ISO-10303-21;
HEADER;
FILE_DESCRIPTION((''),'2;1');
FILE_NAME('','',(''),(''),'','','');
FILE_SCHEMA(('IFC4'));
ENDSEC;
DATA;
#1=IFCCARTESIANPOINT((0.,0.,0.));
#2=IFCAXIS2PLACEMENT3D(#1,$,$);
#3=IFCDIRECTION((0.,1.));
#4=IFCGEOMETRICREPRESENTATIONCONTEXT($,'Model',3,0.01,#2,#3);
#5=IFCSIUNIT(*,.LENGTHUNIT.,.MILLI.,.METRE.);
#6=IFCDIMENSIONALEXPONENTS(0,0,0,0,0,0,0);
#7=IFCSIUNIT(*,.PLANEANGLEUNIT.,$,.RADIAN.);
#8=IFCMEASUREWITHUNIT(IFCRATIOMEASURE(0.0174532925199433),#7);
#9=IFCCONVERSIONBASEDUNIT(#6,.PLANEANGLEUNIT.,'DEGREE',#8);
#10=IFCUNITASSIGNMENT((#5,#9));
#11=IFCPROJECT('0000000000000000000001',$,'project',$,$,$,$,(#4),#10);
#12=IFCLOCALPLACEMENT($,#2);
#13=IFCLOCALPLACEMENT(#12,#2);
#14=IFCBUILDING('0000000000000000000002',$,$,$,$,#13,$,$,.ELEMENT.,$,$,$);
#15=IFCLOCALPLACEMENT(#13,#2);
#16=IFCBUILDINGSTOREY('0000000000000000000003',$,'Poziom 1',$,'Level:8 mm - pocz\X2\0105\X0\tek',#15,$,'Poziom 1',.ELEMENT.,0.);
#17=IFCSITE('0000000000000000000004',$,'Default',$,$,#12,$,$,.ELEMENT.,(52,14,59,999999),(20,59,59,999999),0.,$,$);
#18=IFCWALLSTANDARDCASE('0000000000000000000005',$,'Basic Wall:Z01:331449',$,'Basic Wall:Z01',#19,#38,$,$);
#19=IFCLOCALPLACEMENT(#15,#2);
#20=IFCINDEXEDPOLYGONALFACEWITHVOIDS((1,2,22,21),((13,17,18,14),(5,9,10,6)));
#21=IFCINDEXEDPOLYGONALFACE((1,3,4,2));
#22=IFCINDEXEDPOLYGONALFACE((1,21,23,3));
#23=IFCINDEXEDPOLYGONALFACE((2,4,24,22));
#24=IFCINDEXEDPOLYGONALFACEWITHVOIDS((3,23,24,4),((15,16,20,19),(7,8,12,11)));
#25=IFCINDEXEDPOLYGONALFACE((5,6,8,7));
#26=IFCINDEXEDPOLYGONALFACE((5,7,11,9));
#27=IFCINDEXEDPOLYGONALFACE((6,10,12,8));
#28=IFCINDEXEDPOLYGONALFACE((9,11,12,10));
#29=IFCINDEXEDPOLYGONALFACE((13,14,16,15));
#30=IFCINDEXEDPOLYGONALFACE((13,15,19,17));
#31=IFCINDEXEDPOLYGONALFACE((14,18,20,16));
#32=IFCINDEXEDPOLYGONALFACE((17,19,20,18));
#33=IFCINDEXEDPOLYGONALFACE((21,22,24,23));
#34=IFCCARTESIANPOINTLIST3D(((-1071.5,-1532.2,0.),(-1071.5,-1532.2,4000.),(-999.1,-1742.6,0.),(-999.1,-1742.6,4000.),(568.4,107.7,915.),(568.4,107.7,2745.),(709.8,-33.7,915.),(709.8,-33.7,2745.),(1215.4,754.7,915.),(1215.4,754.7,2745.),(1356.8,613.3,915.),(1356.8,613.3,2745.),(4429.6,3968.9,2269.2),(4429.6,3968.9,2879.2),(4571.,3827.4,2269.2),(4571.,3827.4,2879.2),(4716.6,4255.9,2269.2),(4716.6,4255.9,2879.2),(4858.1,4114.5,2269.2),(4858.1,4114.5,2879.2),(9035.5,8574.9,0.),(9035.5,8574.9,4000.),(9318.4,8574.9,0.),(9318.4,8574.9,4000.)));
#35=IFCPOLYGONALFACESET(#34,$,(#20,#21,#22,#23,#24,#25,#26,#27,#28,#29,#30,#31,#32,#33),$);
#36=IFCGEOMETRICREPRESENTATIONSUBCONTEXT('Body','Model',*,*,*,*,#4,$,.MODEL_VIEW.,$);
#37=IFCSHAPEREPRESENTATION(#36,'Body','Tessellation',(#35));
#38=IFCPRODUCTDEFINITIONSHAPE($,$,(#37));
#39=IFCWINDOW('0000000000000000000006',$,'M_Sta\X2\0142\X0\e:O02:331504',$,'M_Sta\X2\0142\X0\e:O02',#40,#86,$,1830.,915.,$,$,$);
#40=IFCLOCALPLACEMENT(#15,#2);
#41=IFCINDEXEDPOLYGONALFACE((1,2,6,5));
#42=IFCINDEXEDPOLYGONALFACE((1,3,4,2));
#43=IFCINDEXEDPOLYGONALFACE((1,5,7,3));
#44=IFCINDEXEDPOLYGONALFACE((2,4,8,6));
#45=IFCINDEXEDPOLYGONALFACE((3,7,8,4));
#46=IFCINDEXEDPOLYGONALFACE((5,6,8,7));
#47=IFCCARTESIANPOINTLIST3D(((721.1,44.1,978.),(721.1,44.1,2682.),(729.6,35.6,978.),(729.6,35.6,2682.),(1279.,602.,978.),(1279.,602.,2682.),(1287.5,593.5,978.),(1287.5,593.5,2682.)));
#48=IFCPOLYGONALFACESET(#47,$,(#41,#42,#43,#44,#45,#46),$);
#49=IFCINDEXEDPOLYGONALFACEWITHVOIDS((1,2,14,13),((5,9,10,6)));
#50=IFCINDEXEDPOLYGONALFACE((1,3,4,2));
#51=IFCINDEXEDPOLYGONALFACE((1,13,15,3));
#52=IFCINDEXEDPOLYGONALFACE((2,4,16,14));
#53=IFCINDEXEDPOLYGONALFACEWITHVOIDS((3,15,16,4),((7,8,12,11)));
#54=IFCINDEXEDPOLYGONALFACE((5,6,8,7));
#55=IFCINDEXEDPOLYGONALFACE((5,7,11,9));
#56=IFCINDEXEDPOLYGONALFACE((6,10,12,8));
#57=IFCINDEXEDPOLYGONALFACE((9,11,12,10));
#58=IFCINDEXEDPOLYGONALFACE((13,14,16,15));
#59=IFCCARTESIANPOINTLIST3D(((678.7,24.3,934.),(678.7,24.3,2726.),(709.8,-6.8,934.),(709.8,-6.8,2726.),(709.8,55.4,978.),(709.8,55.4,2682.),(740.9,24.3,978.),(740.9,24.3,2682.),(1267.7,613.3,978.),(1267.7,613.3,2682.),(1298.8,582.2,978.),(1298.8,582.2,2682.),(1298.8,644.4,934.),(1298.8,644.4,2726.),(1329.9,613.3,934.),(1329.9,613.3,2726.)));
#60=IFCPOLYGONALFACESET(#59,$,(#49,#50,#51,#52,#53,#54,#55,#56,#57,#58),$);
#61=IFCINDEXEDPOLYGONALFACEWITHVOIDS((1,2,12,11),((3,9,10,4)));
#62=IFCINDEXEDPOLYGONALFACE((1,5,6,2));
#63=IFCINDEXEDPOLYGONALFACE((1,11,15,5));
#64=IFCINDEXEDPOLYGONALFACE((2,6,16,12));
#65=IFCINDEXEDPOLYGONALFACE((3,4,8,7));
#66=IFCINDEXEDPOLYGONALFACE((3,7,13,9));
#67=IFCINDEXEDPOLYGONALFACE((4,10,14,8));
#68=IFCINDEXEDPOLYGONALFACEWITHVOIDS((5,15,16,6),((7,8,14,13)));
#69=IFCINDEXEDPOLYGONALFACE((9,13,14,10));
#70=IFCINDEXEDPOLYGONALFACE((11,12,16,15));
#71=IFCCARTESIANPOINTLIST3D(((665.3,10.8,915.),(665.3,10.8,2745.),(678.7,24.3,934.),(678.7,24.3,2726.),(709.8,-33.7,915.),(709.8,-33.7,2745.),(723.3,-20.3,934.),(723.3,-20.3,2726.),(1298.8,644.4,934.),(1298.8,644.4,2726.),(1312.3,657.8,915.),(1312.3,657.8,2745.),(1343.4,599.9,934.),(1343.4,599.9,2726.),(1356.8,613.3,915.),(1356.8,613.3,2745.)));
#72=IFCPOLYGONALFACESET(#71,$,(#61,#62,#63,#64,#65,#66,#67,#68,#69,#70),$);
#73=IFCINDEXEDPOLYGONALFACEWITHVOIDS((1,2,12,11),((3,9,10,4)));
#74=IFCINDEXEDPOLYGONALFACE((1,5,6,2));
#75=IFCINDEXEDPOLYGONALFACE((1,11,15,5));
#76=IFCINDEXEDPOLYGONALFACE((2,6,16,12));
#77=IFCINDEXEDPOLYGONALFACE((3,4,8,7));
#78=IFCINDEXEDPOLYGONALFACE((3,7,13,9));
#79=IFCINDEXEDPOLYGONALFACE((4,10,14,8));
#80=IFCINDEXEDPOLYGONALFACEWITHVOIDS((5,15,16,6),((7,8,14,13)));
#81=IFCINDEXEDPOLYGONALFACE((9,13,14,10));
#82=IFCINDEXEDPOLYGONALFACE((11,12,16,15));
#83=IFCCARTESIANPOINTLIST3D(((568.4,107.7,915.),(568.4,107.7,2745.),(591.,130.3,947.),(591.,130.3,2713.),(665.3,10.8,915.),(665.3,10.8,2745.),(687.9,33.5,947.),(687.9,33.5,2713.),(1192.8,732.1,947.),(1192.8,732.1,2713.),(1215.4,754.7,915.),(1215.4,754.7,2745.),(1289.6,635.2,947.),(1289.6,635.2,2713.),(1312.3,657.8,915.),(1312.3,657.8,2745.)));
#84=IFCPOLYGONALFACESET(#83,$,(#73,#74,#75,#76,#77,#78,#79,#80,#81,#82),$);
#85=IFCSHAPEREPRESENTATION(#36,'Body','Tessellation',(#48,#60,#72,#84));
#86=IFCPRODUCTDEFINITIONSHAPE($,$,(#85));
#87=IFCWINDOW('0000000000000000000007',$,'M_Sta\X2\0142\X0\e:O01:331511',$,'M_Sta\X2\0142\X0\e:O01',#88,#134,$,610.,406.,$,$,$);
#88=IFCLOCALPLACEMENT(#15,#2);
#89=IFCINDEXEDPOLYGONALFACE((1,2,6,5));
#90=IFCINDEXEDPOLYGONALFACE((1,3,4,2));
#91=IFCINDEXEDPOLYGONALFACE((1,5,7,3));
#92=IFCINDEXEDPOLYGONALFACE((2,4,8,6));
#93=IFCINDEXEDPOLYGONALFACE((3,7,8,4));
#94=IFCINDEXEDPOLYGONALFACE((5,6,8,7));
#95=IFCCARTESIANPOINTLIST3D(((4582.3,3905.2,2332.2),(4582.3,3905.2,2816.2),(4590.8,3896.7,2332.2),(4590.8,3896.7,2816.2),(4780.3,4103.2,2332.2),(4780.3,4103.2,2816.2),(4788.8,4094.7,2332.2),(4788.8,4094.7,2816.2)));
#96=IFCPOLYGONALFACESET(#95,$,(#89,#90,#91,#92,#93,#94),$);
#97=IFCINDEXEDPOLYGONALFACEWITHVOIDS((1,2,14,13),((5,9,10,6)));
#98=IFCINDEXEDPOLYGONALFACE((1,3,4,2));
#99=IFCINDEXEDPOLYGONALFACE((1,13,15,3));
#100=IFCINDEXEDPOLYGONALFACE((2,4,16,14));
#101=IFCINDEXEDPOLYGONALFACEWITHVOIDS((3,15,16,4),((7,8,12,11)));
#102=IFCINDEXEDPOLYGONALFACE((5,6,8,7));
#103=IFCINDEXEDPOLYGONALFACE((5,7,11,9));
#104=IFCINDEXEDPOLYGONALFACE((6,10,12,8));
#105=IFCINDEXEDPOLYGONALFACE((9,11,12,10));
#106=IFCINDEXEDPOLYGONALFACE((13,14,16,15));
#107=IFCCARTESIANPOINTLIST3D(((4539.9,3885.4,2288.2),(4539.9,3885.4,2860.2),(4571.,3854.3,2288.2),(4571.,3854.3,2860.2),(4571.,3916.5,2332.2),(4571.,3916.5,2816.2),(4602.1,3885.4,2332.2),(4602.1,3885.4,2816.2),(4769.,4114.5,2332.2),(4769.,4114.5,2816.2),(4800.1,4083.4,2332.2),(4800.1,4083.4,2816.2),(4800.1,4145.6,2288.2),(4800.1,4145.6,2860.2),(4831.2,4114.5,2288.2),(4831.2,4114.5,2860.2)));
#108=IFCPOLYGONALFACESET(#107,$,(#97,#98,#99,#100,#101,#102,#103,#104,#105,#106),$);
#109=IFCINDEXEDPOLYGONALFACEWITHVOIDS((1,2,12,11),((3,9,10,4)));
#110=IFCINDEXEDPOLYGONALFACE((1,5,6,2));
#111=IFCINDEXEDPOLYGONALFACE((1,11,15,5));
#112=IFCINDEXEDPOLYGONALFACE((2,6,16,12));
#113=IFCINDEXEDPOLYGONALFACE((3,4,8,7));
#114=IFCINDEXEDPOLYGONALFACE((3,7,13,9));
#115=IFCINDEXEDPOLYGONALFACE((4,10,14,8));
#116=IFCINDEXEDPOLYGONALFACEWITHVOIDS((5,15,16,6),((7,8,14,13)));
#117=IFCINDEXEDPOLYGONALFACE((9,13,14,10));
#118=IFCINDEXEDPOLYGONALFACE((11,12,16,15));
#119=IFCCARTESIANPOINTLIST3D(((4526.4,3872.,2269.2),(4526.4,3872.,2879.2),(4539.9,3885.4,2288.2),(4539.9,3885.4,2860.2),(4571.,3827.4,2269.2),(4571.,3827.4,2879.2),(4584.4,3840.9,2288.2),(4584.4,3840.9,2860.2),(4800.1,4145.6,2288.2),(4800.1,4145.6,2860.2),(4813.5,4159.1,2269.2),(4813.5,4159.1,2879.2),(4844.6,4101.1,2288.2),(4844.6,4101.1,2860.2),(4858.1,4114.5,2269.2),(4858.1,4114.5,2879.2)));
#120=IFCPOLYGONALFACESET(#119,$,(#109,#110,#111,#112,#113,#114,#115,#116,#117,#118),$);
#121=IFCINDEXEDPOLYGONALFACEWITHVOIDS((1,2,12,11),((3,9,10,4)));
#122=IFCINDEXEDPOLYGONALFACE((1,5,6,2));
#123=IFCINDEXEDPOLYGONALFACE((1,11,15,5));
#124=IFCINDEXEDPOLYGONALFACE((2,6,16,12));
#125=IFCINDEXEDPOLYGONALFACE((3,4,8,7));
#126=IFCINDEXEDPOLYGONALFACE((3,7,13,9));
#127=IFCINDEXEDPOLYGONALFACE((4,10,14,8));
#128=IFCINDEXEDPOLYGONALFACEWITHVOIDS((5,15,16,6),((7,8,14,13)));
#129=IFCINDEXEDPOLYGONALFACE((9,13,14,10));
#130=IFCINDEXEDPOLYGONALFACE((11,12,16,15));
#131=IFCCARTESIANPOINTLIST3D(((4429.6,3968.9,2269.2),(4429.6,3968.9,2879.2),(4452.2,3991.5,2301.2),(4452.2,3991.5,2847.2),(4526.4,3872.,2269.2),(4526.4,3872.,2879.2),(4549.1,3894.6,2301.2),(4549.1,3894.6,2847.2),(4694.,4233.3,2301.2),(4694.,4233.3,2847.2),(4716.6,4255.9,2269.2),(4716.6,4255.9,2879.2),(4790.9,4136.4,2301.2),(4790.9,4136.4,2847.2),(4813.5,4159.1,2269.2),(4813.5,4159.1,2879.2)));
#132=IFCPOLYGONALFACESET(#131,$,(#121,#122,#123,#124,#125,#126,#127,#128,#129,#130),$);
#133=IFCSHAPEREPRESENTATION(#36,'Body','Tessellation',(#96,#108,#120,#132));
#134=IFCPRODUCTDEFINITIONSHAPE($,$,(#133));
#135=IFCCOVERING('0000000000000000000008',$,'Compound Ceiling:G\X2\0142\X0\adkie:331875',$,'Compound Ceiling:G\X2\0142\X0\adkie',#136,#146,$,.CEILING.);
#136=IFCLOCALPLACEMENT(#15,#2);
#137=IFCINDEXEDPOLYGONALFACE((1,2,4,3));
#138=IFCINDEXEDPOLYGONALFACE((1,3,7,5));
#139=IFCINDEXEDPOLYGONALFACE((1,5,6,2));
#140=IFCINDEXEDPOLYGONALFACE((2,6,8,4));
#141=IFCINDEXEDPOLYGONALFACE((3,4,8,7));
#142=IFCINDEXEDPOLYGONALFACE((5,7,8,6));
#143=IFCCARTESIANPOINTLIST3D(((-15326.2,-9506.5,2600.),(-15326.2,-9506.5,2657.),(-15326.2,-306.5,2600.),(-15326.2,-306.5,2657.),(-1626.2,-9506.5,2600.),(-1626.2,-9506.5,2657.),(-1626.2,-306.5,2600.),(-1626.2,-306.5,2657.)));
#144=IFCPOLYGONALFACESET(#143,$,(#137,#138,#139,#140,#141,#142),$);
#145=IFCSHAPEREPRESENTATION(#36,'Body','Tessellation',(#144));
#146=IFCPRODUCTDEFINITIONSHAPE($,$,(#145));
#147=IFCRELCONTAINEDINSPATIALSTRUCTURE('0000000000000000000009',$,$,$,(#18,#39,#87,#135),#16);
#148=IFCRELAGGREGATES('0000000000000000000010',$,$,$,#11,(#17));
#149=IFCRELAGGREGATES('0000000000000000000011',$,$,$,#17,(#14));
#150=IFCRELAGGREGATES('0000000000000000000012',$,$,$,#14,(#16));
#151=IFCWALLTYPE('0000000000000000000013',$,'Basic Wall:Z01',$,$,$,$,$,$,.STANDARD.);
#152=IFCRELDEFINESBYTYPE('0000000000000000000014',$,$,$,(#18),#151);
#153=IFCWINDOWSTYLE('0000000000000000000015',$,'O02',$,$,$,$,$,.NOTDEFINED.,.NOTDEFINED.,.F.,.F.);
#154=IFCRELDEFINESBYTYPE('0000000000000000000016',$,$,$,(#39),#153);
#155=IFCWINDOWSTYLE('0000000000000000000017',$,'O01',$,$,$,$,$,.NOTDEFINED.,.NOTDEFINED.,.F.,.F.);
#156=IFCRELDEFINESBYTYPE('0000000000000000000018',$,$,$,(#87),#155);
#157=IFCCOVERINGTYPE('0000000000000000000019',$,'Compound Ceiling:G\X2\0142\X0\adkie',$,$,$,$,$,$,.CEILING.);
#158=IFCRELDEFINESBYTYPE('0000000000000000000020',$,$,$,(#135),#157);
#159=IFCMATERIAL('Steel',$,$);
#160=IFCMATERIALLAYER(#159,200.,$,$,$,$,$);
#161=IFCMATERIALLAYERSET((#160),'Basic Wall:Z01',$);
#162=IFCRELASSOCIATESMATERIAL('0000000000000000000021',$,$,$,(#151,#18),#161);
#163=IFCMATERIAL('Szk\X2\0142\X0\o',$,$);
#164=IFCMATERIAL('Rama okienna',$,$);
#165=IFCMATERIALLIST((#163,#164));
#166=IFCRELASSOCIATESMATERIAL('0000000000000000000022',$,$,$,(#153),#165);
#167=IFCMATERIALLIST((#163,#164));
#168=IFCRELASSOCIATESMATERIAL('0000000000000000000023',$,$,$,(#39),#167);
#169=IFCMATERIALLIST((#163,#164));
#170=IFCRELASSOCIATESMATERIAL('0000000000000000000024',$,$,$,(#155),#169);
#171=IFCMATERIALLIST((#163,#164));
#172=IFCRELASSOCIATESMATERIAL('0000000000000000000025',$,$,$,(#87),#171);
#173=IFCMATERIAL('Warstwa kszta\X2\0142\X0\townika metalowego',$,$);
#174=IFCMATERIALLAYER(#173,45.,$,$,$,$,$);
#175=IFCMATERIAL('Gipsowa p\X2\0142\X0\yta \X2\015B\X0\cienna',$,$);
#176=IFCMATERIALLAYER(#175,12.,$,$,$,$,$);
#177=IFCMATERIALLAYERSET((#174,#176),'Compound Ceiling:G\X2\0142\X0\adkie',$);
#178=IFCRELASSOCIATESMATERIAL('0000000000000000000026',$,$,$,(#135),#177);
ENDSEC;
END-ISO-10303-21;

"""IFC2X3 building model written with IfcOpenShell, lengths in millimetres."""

from ifc_helpers import new_model, entity, si_unit, converted_unit, direction, frame, frame_2d, origin, origin_2d_with_axis, place, context, subcontext, project, spatial, polyline, rectangle, outline, extrude, clip, halfspace, source, transform, mapped, material, material_list, layer, layer_set, layer_usage, type_object, type_shapes, element, fill, save


model = new_model("IFC2X3")

# Units and contexts
model_context = context("Model", 3, precision=0.01, world=origin(), true_north=direction((0.0, 1.0)))
body_context = subcontext(model_context, "Body", "Model", "MODEL_VIEW")
ifc_project = project(units=[si_unit("LENGTHUNIT", "METRE", prefix="MILLI"), converted_unit("PLANEANGLEUNIT", "DEGREE", entity("IfcRatioMeasure", 0.0174532925199433), si_unit("PLANEANGLEUNIT", "RADIAN"), dimensions=[0, 0, 0, 0, 0, 0, 0])], contexts=[model_context])

# Site, building, storey
site_placement = place(None, origin())
site = spatial("IfcSite", under=ifc_project, at=site_placement, Name="Default", CompositionType="ELEMENT", RefLatitude=(52, 14, 59, 999999), RefLongitude=(20, 59, 59, 999999), RefElevation=0.0)
building_placement = place(site_placement, origin())
building = spatial("IfcBuilding", under=site, at=building_placement, CompositionType="ELEMENT")
storey_placement = place(building_placement, origin())
storey = spatial("IfcBuildingStorey", under=building, at=storey_placement, Name="Poziom 1", ObjectType="Level:8 mm - początek", LongName="Poziom 1", CompositionType="ELEMENT", Elevation=0.0)

# Shared definitions
ifc_material_1 = material(Name="Steel")
ifc_layer_1 = layer(ifc_material_1, 200.0)
ifc_layer_set_1 = layer_set([ifc_layer_1], Name="Basic Wall:Z01")
wall_type = type_object("IfcWallType", Name="Basic Wall:Z01", PredefinedType="STANDARD", material=ifc_layer_set_1)

# Wall, openings, windows
ifc_layer_usage_1 = layer_usage(ifc_layer_set_1, "AXIS2", "NEGATIVE", 100.0)
wall_1_placement = place(storey_placement, frame((-1069.8, -1671.9, 0.0), z_axis=(0.0, 0.0, 1.0), x_axis=(0.707107, 0.707107, 0.0)))
wall_1 = element("IfcWallStandardCase", 1, at=wall_1_placement, inside=storey, type_object=wall_type, material=ifc_layer_usage_1, Name="Basic Wall:Z01:331449", ObjectType="Basic Wall:Z01", context=body_context, shape_type="Clipping", body=[
    clip(extrude(outline(polyline([(14591.1, -100.0), (14391.1, 100.0), (13684.0, 100.0), (97.5, 100.0), (0.0, -100.0), (14591.1, -100.0)])), origin(), (0.0, 0.0, 1.0), 4000.0), halfspace(origin(), True)),
])
opening_1_placement = place(wall_1_placement, frame((3331.7, 100.0, 915.0)))
opening_1 = element("IfcOpeningElement", 2, at=opening_1_placement, cuts=wall_1, ObjectType="Opening", context=body_context, shape_type="SweptSolid", body=[
    extrude(rectangle(XDim=1830.0, YDim=915.0, at=frame_2d((915.0, 457.5), x_axis=(1.0, 0.0))), frame((0.0, 0.0, 0.0), z_axis=(0.0, -1.0, 0.0), x_axis=(0.0, 0.0, 1.0)), (0.0, 0.0, 1.0), 200.0),
])
opening_2_placement = place(wall_1_placement, frame((8283.2, 100.0, 2269.2)))
opening_2 = element("IfcOpeningElement", 3, at=opening_2_placement, cuts=wall_1, ObjectType="Opening", context=body_context, shape_type="SweptSolid", body=[
    extrude(rectangle(XDim=610.0, YDim=406.0, at=frame_2d((305.0, 203.0), x_axis=(1.0, 0.0))), frame((0.0, 0.0, 0.0), z_axis=(0.0, -1.0, 0.0), x_axis=(0.0, 0.0, 1.0)), (0.0, 0.0, 1.0), 200.0),
])
ifc_material_2 = material(Name="Szkło")
ifc_material_3 = material(Name="Rama okienna")
ifc_material_list_1 = material_list([ifc_material_2, ifc_material_3])
ifc_material_list_2 = material_list([ifc_material_2, ifc_material_3])
window_style_1 = type_object("IfcWindowStyle", Name="O02", ConstructionType="NOTDEFINED", OperationType="NOTDEFINED", ParameterTakesPrecedence=False, Sizeable=False, material=ifc_material_list_2)
shared_shape_1 = source(origin(), body_context, "Body", "SweptSolid", [
    extrude(rectangle(XDim=12.0, YDim=789.0, at=frame_2d((0.0, 0.0), x_axis=(1.0, 0.0))), frame((457.5, 159.0, 63.0), z_axis=(0.0, 0.0, 1.0), x_axis=(0.0, -1.0, 0.0)), (0.0, 0.0, 1.0), 1704.0),
    extrude(outline(polyline([(-438.5, -896.0), (438.5, -896.0), (438.5, 896.0), (-438.5, 896.0), (-438.5, -896.0)]), holes=[polyline([(-394.5, -852.0), (-394.5, 852.0), (394.5, 852.0), (394.5, -852.0), (-394.5, -852.0)])]), frame((457.5, 137.0, 915.0), z_axis=(0.0, 1.0, 0.0), x_axis=(1.0, 0.0, 0.0)), (0.0, 0.0, 1.0), 44.0),
    extrude(outline(polyline([(-457.5, -915.0), (457.5, -915.0), (457.5, 915.0), (-457.5, 915.0), (-457.5, -915.0)]), holes=[polyline([(-438.5, -896.0), (-438.5, 896.0), (438.5, 896.0), (438.5, -896.0), (-438.5, -896.0)])]), frame((457.5, 137.0, 915.0), z_axis=(0.0, 1.0, 0.0), x_axis=(1.0, 0.0, 0.0)), (0.0, 0.0, 1.0), 63.0),
    extrude(outline(polyline([(-457.5, -915.0), (457.5, -915.0), (457.5, 915.0), (-457.5, 915.0), (-457.5, -915.0)]), holes=[polyline([(-425.5, -883.0), (-425.5, 883.0), (425.5, 883.0), (425.5, -883.0), (-425.5, -883.0)])]), frame((457.5, 0.0, 915.0), z_axis=(0.0, 1.0, 0.0), x_axis=(1.0, 0.0, 0.0)), (0.0, 0.0, 1.0), 137.0),
])
type_shapes(window_style_1, [shared_shape_1])
window_1_placement = place(opening_1_placement, frame((0.0, 0.0, 0.0), z_axis=(0.0, 0.0, 1.0), x_axis=(-1.0, 0.0, 0.0)))
window_1 = element("IfcWindow", 4, at=window_1_placement, inside=storey, type_object=window_style_1, material=ifc_material_list_1, Name="M_Stałe:O02:331504", ObjectType="M_Stałe:O02", OverallHeight=1830.0, OverallWidth=915.0, context=body_context, shape_type="MappedRepresentation", body=[
    mapped(shared_shape_1, transform((0.0, 0.0, 0.0), scale=1.0)),
])
fill(opening_1, window_1)
ifc_material_list_3 = material_list([ifc_material_2, ifc_material_3])
ifc_material_list_4 = material_list([ifc_material_2, ifc_material_3])
window_style_2 = type_object("IfcWindowStyle", Name="O01", ConstructionType="NOTDEFINED", OperationType="NOTDEFINED", ParameterTakesPrecedence=False, Sizeable=False, material=ifc_material_list_4)
shared_shape_2 = source(origin(), body_context, "Body", "SweptSolid", [
    extrude(rectangle(XDim=12.0, YDim=280.0, at=frame_2d((0.0, 0.0), x_axis=(1.0, 0.0))), frame((203.0, 159.0, 63.0), z_axis=(0.0, 0.0, 1.0), x_axis=(0.0, -1.0, 0.0)), (0.0, 0.0, 1.0), 484.0),
    extrude(outline(polyline([(-184.0, -286.0), (184.0, -286.0), (184.0, 286.0), (-184.0, 286.0), (-184.0, -286.0)]), holes=[polyline([(-140.0, -242.0), (-140.0, 242.0), (140.0, 242.0), (140.0, -242.0), (-140.0, -242.0)])]), frame((203.0, 137.0, 305.0), z_axis=(0.0, 1.0, 0.0), x_axis=(1.0, 0.0, 0.0)), (0.0, 0.0, 1.0), 44.0),
    extrude(outline(polyline([(-203.0, -305.0), (203.0, -305.0), (203.0, 305.0), (-203.0, 305.0), (-203.0, -305.0)]), holes=[polyline([(-184.0, -286.0), (-184.0, 286.0), (184.0, 286.0), (184.0, -286.0), (-184.0, -286.0)])]), frame((203.0, 137.0, 305.0), z_axis=(0.0, 1.0, 0.0), x_axis=(1.0, 0.0, 0.0)), (0.0, 0.0, 1.0), 63.0),
    extrude(outline(polyline([(-203.0, -305.0), (203.0, -305.0), (203.0, 305.0), (-203.0, 305.0), (-203.0, -305.0)]), holes=[polyline([(-171.0, -273.0), (-171.0, 273.0), (171.0, 273.0), (171.0, -273.0), (-171.0, -273.0)])]), frame((203.0, 0.0, 305.0), z_axis=(0.0, 1.0, 0.0), x_axis=(1.0, 0.0, 0.0)), (0.0, 0.0, 1.0), 137.0),
])
type_shapes(window_style_2, [shared_shape_2])
window_2_placement = place(opening_2_placement, frame((0.0, 0.0, 0.0), z_axis=(0.0, 0.0, 1.0), x_axis=(-1.0, 0.0, 0.0)))
window_2 = element("IfcWindow", 5, at=window_2_placement, inside=storey, type_object=window_style_2, material=ifc_material_list_3, Name="M_Stałe:O01:331511", ObjectType="M_Stałe:O01", OverallHeight=610.0, OverallWidth=406.0, context=body_context, shape_type="MappedRepresentation", body=[
    mapped(shared_shape_2, transform((0.0, 0.0, 0.0), scale=1.0)),
])
fill(opening_2, window_2)

# Covering
ifc_material_4 = material(Name="Warstwa kształtownika metalowego")
ifc_layer_2 = layer(ifc_material_4, 45.0)
ifc_material_5 = material(Name="Gipsowa płyta ścienna")
ifc_layer_3 = layer(ifc_material_5, 12.0)
ifc_layer_set_2 = layer_set([ifc_layer_2, ifc_layer_3], Name="Compound Ceiling:Gładkie")
ifc_layer_usage_2 = layer_usage(ifc_layer_set_2, "AXIS3", "POSITIVE", 0.0)
covering_type = type_object("IfcCoveringType", Name="Compound Ceiling:Gładkie", PredefinedType="CEILING")
covering_placement = place(storey_placement, origin())
element("IfcCovering", 6, at=covering_placement, inside=storey, type_object=covering_type, material=ifc_layer_usage_2, Name="Compound Ceiling:Gładkie:331875", ObjectType="Compound Ceiling:Gładkie", PredefinedType="CEILING", context=body_context, shape_type="SweptSolid", body=[
    extrude(rectangle(XDim=13700.0, YDim=9200.0, at=origin_2d_with_axis()), frame((-8476.2, -4906.5, 2600.0), z_axis=(0.0, 0.0, 1.0), x_axis=(-1.0, 0.0, 0.0)), (0.0, 0.0, 1.0), 57.0),
])

save(model, "model.ifc")
